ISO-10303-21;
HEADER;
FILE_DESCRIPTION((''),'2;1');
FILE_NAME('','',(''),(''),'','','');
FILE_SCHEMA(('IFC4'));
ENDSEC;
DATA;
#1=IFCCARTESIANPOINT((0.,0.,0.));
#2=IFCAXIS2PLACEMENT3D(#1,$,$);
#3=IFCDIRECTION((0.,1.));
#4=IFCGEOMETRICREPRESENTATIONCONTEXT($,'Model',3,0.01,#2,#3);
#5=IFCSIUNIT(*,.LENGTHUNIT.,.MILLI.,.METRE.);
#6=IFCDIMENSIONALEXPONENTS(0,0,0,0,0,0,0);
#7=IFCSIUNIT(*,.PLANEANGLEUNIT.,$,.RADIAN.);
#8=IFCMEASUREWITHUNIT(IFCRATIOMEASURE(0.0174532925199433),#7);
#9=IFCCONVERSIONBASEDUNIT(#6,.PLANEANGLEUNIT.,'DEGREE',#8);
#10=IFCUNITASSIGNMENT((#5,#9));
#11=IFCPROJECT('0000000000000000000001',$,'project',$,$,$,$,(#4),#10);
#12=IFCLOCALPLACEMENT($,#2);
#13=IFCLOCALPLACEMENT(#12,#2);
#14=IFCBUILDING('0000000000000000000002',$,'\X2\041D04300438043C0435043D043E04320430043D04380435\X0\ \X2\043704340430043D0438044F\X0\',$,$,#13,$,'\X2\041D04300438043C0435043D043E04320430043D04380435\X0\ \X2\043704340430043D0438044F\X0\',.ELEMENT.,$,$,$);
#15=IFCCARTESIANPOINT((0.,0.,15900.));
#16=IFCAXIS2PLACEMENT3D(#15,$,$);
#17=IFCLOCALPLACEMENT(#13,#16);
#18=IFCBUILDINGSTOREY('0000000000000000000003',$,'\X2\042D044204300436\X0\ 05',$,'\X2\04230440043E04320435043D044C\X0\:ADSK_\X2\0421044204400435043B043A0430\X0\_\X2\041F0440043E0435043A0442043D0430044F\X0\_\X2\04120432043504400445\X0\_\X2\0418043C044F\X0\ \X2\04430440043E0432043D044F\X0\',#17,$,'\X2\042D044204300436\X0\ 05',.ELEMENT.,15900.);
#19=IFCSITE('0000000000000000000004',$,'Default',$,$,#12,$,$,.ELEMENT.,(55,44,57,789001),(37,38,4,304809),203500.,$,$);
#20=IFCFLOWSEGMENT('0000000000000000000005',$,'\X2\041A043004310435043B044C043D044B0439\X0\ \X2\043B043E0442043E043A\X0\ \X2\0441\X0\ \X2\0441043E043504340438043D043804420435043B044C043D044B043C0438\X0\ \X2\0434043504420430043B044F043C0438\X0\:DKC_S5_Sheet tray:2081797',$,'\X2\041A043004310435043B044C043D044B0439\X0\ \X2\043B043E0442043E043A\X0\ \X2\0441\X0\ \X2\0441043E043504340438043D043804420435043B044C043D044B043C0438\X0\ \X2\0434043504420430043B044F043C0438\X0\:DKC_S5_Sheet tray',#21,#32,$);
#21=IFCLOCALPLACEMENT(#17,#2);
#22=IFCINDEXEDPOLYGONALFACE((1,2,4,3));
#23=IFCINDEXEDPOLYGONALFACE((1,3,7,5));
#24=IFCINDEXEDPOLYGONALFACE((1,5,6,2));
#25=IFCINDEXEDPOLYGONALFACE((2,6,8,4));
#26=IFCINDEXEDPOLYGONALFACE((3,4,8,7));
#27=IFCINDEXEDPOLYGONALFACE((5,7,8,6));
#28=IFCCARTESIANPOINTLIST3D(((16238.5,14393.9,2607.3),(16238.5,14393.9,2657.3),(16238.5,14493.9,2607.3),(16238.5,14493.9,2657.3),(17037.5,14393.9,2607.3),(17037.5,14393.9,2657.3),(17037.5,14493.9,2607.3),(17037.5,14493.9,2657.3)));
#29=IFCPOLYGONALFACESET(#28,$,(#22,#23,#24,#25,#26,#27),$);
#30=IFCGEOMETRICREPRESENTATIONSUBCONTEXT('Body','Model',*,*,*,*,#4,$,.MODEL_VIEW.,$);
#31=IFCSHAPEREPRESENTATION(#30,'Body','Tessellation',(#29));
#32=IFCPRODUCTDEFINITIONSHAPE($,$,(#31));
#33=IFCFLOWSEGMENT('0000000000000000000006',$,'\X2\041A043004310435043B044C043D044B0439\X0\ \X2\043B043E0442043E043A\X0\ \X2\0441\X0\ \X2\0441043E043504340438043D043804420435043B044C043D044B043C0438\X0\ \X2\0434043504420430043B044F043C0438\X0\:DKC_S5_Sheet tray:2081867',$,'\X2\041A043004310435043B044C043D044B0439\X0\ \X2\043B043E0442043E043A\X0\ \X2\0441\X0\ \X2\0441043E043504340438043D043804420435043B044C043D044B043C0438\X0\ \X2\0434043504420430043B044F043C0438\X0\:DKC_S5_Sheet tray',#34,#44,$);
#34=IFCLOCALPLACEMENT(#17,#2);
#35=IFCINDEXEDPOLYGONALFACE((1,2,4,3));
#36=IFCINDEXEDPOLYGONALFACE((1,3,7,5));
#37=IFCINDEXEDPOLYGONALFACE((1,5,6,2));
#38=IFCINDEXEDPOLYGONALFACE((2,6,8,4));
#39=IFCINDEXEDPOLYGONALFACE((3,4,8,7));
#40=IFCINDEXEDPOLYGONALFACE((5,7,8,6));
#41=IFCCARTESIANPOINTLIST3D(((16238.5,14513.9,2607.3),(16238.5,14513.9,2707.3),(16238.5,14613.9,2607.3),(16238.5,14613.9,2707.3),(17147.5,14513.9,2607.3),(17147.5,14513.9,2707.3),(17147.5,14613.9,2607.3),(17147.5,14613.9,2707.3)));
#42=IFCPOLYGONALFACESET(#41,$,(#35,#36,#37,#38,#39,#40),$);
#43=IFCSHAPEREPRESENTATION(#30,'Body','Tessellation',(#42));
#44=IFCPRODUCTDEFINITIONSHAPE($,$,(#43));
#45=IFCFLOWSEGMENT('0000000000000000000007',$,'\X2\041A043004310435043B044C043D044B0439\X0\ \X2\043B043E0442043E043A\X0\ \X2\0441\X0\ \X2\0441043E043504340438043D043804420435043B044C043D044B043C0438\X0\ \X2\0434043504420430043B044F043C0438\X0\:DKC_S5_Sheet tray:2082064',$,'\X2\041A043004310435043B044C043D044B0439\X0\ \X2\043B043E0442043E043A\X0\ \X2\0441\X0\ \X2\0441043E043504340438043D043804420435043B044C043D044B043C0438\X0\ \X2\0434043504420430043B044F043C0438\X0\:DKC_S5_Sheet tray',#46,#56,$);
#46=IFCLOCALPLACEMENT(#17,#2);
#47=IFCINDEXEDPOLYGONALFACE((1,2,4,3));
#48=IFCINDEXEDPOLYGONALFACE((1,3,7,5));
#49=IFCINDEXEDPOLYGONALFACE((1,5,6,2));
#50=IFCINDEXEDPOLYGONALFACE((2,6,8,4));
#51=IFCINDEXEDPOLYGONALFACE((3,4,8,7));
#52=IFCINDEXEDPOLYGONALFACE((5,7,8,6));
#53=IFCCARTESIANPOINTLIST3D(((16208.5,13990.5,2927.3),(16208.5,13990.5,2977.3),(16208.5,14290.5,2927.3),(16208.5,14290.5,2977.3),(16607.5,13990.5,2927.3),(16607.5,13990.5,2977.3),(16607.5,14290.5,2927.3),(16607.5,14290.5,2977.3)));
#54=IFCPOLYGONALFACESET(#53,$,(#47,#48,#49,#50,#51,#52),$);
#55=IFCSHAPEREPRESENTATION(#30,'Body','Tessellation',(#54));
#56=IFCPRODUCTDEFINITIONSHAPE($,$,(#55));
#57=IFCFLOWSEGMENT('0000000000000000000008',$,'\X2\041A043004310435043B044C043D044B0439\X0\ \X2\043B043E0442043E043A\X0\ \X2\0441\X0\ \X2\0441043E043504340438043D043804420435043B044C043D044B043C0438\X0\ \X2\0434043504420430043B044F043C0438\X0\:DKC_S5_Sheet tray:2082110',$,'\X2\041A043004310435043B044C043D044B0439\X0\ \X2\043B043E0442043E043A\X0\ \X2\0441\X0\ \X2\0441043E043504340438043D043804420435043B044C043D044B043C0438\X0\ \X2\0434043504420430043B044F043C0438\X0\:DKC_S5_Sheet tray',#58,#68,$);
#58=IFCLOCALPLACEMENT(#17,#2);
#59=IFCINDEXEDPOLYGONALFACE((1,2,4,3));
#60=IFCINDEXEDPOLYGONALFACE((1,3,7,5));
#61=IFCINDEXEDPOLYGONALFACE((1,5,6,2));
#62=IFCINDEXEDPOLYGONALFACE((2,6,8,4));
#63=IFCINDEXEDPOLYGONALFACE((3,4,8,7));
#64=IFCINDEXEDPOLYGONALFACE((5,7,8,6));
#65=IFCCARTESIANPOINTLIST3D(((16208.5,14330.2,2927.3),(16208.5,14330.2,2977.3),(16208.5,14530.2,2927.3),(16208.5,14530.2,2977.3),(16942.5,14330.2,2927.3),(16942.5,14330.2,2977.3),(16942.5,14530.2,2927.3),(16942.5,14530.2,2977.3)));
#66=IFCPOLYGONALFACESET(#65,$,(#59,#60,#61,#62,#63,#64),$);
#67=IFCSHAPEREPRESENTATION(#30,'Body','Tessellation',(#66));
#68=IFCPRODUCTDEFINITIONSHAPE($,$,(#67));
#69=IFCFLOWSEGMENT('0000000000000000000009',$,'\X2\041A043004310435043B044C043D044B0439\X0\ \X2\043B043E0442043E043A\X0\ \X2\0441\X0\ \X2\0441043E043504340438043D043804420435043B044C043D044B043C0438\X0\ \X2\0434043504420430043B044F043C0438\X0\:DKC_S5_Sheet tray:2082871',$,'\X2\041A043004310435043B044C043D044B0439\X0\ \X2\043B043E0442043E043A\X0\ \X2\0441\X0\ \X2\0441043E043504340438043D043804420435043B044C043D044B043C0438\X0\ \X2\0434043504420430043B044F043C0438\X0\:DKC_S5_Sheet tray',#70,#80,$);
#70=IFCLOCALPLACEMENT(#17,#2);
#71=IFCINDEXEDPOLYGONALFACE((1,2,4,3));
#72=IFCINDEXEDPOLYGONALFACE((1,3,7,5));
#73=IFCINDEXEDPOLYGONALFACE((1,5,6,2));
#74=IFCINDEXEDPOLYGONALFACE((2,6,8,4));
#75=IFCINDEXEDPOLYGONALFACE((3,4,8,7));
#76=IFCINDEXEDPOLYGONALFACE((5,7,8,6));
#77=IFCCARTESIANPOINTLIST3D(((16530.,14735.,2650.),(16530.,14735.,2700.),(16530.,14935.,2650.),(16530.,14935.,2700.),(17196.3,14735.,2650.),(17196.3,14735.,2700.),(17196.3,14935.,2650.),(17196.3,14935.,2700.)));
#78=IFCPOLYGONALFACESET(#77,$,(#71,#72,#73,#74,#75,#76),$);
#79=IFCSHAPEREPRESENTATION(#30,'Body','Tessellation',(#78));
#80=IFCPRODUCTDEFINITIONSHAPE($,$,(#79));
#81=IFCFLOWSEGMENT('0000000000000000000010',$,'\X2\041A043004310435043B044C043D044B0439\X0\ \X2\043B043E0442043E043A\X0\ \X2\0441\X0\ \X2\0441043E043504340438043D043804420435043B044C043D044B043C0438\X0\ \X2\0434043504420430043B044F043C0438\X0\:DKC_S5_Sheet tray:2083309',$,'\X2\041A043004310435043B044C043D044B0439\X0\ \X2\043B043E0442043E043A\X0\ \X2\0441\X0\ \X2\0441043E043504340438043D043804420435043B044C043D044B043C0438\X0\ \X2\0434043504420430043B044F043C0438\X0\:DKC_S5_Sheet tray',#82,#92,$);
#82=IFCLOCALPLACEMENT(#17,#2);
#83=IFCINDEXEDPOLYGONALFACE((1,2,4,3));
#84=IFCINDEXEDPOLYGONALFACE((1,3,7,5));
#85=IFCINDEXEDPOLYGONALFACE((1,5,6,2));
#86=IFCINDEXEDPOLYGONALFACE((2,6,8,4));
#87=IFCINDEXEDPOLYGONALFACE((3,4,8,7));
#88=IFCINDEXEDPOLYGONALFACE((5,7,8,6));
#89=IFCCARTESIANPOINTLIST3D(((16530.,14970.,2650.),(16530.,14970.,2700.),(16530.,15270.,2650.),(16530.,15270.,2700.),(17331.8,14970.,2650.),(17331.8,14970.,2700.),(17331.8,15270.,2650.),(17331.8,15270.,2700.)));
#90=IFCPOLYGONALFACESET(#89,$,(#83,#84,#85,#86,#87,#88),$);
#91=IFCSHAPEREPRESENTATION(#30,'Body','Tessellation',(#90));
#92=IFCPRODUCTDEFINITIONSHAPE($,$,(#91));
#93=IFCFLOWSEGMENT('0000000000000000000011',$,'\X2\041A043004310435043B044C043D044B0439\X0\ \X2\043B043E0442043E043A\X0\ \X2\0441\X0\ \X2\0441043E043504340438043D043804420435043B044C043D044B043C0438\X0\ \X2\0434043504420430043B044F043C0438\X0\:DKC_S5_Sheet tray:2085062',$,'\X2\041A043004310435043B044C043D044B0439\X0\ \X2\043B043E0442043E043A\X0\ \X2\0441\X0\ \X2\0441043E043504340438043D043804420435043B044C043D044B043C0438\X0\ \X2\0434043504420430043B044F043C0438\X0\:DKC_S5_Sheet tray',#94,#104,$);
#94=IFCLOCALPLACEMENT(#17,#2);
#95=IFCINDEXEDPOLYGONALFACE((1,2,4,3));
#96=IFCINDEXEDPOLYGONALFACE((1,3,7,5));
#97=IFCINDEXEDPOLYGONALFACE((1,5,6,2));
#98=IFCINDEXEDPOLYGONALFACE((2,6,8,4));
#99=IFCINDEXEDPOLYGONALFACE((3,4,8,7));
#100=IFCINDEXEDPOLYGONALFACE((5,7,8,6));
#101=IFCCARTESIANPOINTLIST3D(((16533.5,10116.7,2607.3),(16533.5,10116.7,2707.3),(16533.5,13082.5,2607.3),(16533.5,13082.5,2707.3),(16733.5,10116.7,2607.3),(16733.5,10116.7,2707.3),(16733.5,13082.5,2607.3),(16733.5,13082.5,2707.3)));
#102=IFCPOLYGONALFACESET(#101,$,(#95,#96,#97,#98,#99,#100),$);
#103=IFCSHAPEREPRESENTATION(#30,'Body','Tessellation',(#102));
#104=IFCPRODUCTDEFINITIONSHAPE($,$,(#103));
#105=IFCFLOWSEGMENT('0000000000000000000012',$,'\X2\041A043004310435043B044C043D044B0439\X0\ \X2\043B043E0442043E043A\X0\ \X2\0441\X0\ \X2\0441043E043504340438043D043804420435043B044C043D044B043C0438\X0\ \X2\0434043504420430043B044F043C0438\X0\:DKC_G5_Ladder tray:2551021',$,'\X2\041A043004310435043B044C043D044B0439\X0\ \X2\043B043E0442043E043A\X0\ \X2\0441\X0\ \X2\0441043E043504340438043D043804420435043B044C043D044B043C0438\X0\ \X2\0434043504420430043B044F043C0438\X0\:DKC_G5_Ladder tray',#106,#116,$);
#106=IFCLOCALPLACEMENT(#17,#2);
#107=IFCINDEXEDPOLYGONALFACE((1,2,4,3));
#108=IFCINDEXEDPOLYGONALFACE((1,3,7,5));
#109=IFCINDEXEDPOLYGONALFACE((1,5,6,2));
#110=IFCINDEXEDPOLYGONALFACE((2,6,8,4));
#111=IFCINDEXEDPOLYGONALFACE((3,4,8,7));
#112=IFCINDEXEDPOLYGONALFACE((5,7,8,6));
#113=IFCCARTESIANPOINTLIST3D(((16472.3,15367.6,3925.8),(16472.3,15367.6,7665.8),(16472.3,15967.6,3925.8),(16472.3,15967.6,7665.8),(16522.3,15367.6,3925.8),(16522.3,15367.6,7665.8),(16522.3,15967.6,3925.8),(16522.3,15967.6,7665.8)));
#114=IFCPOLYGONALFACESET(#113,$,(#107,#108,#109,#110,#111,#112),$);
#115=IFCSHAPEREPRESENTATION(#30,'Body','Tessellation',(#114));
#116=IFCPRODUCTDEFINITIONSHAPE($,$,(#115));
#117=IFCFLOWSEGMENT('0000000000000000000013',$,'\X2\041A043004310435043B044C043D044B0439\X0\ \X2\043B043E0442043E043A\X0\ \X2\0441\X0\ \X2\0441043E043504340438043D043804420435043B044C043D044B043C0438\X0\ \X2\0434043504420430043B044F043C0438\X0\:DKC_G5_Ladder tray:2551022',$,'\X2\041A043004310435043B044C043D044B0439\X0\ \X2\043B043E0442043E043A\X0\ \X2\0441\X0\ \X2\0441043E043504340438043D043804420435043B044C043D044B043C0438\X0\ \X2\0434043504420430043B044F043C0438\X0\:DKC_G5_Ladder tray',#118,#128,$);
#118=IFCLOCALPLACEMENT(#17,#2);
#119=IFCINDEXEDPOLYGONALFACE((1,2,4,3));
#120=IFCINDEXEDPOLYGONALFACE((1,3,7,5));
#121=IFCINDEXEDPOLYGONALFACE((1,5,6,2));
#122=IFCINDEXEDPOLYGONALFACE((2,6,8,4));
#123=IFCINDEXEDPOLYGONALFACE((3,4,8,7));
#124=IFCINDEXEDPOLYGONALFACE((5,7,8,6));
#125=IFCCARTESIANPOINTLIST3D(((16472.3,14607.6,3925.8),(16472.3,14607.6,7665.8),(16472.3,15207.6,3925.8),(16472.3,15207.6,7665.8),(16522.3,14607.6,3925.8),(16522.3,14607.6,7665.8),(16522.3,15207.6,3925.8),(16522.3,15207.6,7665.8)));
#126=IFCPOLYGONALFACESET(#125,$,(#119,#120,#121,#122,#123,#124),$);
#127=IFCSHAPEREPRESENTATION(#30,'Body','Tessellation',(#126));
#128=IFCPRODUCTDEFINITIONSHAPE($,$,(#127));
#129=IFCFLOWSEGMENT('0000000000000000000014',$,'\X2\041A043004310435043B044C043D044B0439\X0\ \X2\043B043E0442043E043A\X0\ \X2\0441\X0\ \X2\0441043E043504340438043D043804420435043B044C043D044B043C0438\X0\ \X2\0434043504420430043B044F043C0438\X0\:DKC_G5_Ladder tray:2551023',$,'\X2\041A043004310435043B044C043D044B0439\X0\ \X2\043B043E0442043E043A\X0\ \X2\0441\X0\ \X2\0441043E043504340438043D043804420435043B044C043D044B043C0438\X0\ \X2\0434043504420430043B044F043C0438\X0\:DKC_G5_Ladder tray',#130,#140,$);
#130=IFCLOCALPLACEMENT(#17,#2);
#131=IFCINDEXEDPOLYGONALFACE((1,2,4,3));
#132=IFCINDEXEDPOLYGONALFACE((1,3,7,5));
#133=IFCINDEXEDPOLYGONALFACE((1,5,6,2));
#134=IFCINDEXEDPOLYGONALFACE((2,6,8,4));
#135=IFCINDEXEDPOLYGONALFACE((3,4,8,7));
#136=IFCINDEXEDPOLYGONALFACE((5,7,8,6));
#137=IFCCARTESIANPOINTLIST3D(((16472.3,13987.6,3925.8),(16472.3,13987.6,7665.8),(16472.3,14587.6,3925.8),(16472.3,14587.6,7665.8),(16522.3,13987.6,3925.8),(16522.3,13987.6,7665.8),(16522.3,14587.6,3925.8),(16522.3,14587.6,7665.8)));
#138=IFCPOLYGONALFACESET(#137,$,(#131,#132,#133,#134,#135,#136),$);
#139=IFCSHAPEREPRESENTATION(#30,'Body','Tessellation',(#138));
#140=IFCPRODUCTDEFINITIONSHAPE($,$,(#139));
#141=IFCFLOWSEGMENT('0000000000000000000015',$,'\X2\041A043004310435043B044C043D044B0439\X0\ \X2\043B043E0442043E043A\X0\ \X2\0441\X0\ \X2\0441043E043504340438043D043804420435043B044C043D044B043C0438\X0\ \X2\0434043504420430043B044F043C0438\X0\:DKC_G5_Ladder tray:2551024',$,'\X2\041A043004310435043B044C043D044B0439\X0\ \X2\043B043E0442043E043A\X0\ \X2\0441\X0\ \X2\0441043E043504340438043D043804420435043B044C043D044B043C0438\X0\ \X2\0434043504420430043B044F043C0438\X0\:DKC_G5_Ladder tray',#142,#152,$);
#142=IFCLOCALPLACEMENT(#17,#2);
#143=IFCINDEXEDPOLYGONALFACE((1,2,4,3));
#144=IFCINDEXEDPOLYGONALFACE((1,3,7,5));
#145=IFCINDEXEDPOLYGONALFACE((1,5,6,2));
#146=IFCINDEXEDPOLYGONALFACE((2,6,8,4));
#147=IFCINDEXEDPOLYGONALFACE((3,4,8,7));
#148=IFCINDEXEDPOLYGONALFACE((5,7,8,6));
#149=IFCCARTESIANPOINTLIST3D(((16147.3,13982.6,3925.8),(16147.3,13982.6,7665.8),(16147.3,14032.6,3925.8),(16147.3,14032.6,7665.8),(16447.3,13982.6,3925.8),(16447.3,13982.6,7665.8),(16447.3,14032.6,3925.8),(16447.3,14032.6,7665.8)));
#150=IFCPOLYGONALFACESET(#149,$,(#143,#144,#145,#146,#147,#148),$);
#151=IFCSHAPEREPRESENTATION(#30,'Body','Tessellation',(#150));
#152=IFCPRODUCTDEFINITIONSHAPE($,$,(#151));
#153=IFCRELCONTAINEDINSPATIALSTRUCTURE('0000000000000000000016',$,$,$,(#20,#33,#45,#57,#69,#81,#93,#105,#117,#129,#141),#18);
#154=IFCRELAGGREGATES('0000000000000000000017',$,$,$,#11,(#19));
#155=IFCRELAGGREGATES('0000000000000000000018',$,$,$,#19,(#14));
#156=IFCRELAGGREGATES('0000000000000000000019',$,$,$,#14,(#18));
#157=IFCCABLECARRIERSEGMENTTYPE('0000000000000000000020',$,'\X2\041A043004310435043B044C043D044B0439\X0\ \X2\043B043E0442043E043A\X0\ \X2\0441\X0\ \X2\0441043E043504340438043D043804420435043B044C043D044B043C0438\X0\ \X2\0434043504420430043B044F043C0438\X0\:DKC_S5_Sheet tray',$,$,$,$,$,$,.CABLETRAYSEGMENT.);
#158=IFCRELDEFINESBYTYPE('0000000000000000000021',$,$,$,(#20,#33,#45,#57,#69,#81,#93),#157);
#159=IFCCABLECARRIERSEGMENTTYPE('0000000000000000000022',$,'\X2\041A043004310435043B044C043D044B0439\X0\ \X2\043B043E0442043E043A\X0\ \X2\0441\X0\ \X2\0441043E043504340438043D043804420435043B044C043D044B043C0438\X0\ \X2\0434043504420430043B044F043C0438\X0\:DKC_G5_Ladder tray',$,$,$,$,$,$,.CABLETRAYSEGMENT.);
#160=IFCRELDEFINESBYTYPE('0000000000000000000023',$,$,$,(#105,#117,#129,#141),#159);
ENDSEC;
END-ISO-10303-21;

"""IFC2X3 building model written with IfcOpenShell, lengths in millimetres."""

from ifc_helpers import new_model, entity, si_unit, converted_unit, direction, frame, origin, origin_2d_with_axis, place, context, subcontext, project, spatial, rectangle, extrude, type_object, element, save


model = new_model("IFC2X3")

# Units and contexts
model_context = context("Model", 3, precision=0.01, world=origin(), true_north=direction((0.0, 1.0)))
body_context = subcontext(model_context, "Body", "Model", "MODEL_VIEW")
ifc_project = project(units=[si_unit("LENGTHUNIT", "METRE", prefix="MILLI"), converted_unit("PLANEANGLEUNIT", "DEGREE", entity("IfcRatioMeasure", 0.0174532925199433), si_unit("PLANEANGLEUNIT", "RADIAN"), dimensions=[0, 0, 0, 0, 0, 0, 0])], contexts=[model_context])

# Site, building, storey
site_placement = place(None, origin())
site = spatial("IfcSite", under=ifc_project, at=site_placement, Name="Default", CompositionType="ELEMENT", RefLatitude=(55, 44, 57, 789001), RefLongitude=(37, 38, 4, 304809), RefElevation=203500.0)
building_placement = place(site_placement, origin())
building = spatial("IfcBuilding", under=site, at=building_placement, Name="Наименование здания", LongName="Наименование здания", CompositionType="ELEMENT")
storey_placement = place(building_placement, frame((0.0, 0.0, 15900.0)))
storey = spatial("IfcBuildingStorey", under=building, at=storey_placement, Name="Этаж 05", ObjectType="Уровень:ADSK_Стрелка_Проектная_Вверх_Имя уровня", LongName="Этаж 05", CompositionType="ELEMENT", Elevation=15900.0)

# Flow segments
cable_carrier_segment_type_1 = type_object("IfcCableCarrierSegmentType", Name="Кабельный лоток с соединительными деталями:DKC_S5_Sheet tray", PredefinedType="CABLETRAYSEGMENT")
flow_segment_1_placement = place(storey_placement, frame((16238.5, 14393.9, 2607.3)))
element("IfcFlowSegment", 1, at=flow_segment_1_placement, inside=storey, type_object=cable_carrier_segment_type_1, Name="Кабельный лоток с соединительными деталями:DKC_S5_Sheet tray:2081797", ObjectType="Кабельный лоток с соединительными деталями:DKC_S5_Sheet tray", context=body_context, shape_type="SweptSolid", body=[
    extrude(rectangle(XDim=799.0, YDim=100.0, at=origin_2d_with_axis()), frame((399.5, 50.0, 0.0), z_axis=(0.0, 0.0, 1.0), x_axis=(-1.0, 0.0, 0.0)), (0.0, 0.0, 1.0), 50.0),
])
flow_segment_2_placement = place(storey_placement, frame((16238.5, 14513.9, 2607.3)))
element("IfcFlowSegment", 2, at=flow_segment_2_placement, inside=storey, type_object=cable_carrier_segment_type_1, Name="Кабельный лоток с соединительными деталями:DKC_S5_Sheet tray:2081867", ObjectType="Кабельный лоток с соединительными деталями:DKC_S5_Sheet tray", context=body_context, shape_type="SweptSolid", body=[
    extrude(rectangle(XDim=909.0, YDim=100.0, at=origin_2d_with_axis()), frame((454.5, 50.0, 0.0), z_axis=(0.0, 0.0, 1.0), x_axis=(-1.0, 0.0, 0.0)), (0.0, 0.0, 1.0), 100.0),
])
flow_segment_3_placement = place(storey_placement, frame((16208.5, 13990.5, 2927.3)))
element("IfcFlowSegment", 3, at=flow_segment_3_placement, inside=storey, type_object=cable_carrier_segment_type_1, Name="Кабельный лоток с соединительными деталями:DKC_S5_Sheet tray:2082064", ObjectType="Кабельный лоток с соединительными деталями:DKC_S5_Sheet tray", context=body_context, shape_type="SweptSolid", body=[
    extrude(rectangle(XDim=399.0, YDim=300.0, at=origin_2d_with_axis()), frame((199.5, 150.0, 0.0), z_axis=(0.0, 0.0, 1.0), x_axis=(-1.0, 0.0, 0.0)), (0.0, 0.0, 1.0), 50.0),
])
flow_segment_4_placement = place(storey_placement, frame((16208.5, 14330.2, 2927.3)))
element("IfcFlowSegment", 4, at=flow_segment_4_placement, inside=storey, type_object=cable_carrier_segment_type_1, Name="Кабельный лоток с соединительными деталями:DKC_S5_Sheet tray:2082110", ObjectType="Кабельный лоток с соединительными деталями:DKC_S5_Sheet tray", context=body_context, shape_type="SweptSolid", body=[
    extrude(rectangle(XDim=734.0, YDim=200.0, at=origin_2d_with_axis()), frame((367.0, 100.0, 0.0), z_axis=(0.0, 0.0, 1.0), x_axis=(-1.0, 0.0, 0.0)), (0.0, 0.0, 1.0), 50.0),
])
flow_segment_5_placement = place(storey_placement, frame((16530.0, 14735.0, 2650.0)))
element("IfcFlowSegment", 5, at=flow_segment_5_placement, inside=storey, type_object=cable_carrier_segment_type_1, Name="Кабельный лоток с соединительными деталями:DKC_S5_Sheet tray:2082871", ObjectType="Кабельный лоток с соединительными деталями:DKC_S5_Sheet tray", context=body_context, shape_type="SweptSolid", body=[
    extrude(rectangle(XDim=666.3, YDim=200.0, at=origin_2d_with_axis()), frame((333.1, 100.0, 0.0)), (0.0, 0.0, 1.0), 50.0),
])
flow_segment_6_placement = place(storey_placement, frame((16530.0, 14970.0, 2650.0)))
element("IfcFlowSegment", 6, at=flow_segment_6_placement, inside=storey, type_object=cable_carrier_segment_type_1, Name="Кабельный лоток с соединительными деталями:DKC_S5_Sheet tray:2083309", ObjectType="Кабельный лоток с соединительными деталями:DKC_S5_Sheet tray", context=body_context, shape_type="SweptSolid", body=[
    extrude(rectangle(XDim=801.8, YDim=300.0, at=origin_2d_with_axis()), frame((400.9, 150.0, 0.0)), (0.0, 0.0, 1.0), 50.0),
])
flow_segment_7_placement = place(storey_placement, frame((16533.5, 10116.7, 2607.3)))
element("IfcFlowSegment", 7, at=flow_segment_7_placement, inside=storey, type_object=cable_carrier_segment_type_1, Name="Кабельный лоток с соединительными деталями:DKC_S5_Sheet tray:2085062", ObjectType="Кабельный лоток с соединительными деталями:DKC_S5_Sheet tray", context=body_context, shape_type="SweptSolid", body=[
    extrude(rectangle(XDim=2965.8, YDim=200.0, at=origin_2d_with_axis()), frame((100.0, 1482.9, 0.0), z_axis=(0.0, 0.0, 1.0), x_axis=(0.0, -1.0, 0.0)), (0.0, 0.0, 1.0), 100.0),
])
cable_carrier_segment_type_2 = type_object("IfcCableCarrierSegmentType", Name="Кабельный лоток с соединительными деталями:DKC_G5_Ladder tray", PredefinedType="CABLETRAYSEGMENT")
for number, where, name in (
    (8, (16472.3, 15367.6, 3925.8), "Кабельный лоток с соединительными деталями:DKC_G5_Ladder tray:2551021"),
    (9, (16472.3, 14607.6, 3925.8), "Кабельный лоток с соединительными деталями:DKC_G5_Ladder tray:2551022"),
):
    element("IfcFlowSegment", number, at=place(storey_placement, frame(where)), inside=storey, type_object=cable_carrier_segment_type_2, Name=name, ObjectType="Кабельный лоток с соединительными деталями:DKC_G5_Ladder tray", context=body_context, shape_type="SweptSolid", body=[
        extrude(rectangle(XDim=50.0, YDim=600.0, at=origin_2d_with_axis()), frame((25.0, 300.0, 0.0), z_axis=(0.0, 0.0, 1.0), x_axis=(-1.0, 0.0, 0.0)), (0.0, 0.0, 1.0), 3740.0),
    ])
flow_segment_8_placement = place(storey_placement, frame((16472.3, 13987.6, 3925.8)))
element("IfcFlowSegment", 10, at=flow_segment_8_placement, inside=storey, type_object=cable_carrier_segment_type_2, Name="Кабельный лоток с соединительными деталями:DKC_G5_Ladder tray:2551023", ObjectType="Кабельный лоток с соединительными деталями:DKC_G5_Ladder tray", context=body_context, shape_type="SweptSolid", body=[
    extrude(rectangle(XDim=50.0, YDim=600.0, at=origin_2d_with_axis()), frame((25.0, 300.0, 0.0), z_axis=(0.0, 0.0, 1.0), x_axis=(-1.0, 0.0, 0.0)), (0.0, 0.0, 1.0), 3740.0),
])
flow_segment_9_placement = place(storey_placement, frame((16147.3, 13982.6, 3925.8)))
element("IfcFlowSegment", 11, at=flow_segment_9_placement, inside=storey, type_object=cable_carrier_segment_type_2, Name="Кабельный лоток с соединительными деталями:DKC_G5_Ladder tray:2551024", ObjectType="Кабельный лоток с соединительными деталями:DKC_G5_Ladder tray", context=body_context, shape_type="SweptSolid", body=[
    extrude(rectangle(XDim=50.0, YDim=300.0, at=origin_2d_with_axis()), frame((150.0, 25.0, 0.0), z_axis=(0.0, 0.0, 1.0), x_axis=(0.0, 1.0, 0.0)), (0.0, 0.0, 1.0), 3740.0),
])

save(model, "model.ifc")
